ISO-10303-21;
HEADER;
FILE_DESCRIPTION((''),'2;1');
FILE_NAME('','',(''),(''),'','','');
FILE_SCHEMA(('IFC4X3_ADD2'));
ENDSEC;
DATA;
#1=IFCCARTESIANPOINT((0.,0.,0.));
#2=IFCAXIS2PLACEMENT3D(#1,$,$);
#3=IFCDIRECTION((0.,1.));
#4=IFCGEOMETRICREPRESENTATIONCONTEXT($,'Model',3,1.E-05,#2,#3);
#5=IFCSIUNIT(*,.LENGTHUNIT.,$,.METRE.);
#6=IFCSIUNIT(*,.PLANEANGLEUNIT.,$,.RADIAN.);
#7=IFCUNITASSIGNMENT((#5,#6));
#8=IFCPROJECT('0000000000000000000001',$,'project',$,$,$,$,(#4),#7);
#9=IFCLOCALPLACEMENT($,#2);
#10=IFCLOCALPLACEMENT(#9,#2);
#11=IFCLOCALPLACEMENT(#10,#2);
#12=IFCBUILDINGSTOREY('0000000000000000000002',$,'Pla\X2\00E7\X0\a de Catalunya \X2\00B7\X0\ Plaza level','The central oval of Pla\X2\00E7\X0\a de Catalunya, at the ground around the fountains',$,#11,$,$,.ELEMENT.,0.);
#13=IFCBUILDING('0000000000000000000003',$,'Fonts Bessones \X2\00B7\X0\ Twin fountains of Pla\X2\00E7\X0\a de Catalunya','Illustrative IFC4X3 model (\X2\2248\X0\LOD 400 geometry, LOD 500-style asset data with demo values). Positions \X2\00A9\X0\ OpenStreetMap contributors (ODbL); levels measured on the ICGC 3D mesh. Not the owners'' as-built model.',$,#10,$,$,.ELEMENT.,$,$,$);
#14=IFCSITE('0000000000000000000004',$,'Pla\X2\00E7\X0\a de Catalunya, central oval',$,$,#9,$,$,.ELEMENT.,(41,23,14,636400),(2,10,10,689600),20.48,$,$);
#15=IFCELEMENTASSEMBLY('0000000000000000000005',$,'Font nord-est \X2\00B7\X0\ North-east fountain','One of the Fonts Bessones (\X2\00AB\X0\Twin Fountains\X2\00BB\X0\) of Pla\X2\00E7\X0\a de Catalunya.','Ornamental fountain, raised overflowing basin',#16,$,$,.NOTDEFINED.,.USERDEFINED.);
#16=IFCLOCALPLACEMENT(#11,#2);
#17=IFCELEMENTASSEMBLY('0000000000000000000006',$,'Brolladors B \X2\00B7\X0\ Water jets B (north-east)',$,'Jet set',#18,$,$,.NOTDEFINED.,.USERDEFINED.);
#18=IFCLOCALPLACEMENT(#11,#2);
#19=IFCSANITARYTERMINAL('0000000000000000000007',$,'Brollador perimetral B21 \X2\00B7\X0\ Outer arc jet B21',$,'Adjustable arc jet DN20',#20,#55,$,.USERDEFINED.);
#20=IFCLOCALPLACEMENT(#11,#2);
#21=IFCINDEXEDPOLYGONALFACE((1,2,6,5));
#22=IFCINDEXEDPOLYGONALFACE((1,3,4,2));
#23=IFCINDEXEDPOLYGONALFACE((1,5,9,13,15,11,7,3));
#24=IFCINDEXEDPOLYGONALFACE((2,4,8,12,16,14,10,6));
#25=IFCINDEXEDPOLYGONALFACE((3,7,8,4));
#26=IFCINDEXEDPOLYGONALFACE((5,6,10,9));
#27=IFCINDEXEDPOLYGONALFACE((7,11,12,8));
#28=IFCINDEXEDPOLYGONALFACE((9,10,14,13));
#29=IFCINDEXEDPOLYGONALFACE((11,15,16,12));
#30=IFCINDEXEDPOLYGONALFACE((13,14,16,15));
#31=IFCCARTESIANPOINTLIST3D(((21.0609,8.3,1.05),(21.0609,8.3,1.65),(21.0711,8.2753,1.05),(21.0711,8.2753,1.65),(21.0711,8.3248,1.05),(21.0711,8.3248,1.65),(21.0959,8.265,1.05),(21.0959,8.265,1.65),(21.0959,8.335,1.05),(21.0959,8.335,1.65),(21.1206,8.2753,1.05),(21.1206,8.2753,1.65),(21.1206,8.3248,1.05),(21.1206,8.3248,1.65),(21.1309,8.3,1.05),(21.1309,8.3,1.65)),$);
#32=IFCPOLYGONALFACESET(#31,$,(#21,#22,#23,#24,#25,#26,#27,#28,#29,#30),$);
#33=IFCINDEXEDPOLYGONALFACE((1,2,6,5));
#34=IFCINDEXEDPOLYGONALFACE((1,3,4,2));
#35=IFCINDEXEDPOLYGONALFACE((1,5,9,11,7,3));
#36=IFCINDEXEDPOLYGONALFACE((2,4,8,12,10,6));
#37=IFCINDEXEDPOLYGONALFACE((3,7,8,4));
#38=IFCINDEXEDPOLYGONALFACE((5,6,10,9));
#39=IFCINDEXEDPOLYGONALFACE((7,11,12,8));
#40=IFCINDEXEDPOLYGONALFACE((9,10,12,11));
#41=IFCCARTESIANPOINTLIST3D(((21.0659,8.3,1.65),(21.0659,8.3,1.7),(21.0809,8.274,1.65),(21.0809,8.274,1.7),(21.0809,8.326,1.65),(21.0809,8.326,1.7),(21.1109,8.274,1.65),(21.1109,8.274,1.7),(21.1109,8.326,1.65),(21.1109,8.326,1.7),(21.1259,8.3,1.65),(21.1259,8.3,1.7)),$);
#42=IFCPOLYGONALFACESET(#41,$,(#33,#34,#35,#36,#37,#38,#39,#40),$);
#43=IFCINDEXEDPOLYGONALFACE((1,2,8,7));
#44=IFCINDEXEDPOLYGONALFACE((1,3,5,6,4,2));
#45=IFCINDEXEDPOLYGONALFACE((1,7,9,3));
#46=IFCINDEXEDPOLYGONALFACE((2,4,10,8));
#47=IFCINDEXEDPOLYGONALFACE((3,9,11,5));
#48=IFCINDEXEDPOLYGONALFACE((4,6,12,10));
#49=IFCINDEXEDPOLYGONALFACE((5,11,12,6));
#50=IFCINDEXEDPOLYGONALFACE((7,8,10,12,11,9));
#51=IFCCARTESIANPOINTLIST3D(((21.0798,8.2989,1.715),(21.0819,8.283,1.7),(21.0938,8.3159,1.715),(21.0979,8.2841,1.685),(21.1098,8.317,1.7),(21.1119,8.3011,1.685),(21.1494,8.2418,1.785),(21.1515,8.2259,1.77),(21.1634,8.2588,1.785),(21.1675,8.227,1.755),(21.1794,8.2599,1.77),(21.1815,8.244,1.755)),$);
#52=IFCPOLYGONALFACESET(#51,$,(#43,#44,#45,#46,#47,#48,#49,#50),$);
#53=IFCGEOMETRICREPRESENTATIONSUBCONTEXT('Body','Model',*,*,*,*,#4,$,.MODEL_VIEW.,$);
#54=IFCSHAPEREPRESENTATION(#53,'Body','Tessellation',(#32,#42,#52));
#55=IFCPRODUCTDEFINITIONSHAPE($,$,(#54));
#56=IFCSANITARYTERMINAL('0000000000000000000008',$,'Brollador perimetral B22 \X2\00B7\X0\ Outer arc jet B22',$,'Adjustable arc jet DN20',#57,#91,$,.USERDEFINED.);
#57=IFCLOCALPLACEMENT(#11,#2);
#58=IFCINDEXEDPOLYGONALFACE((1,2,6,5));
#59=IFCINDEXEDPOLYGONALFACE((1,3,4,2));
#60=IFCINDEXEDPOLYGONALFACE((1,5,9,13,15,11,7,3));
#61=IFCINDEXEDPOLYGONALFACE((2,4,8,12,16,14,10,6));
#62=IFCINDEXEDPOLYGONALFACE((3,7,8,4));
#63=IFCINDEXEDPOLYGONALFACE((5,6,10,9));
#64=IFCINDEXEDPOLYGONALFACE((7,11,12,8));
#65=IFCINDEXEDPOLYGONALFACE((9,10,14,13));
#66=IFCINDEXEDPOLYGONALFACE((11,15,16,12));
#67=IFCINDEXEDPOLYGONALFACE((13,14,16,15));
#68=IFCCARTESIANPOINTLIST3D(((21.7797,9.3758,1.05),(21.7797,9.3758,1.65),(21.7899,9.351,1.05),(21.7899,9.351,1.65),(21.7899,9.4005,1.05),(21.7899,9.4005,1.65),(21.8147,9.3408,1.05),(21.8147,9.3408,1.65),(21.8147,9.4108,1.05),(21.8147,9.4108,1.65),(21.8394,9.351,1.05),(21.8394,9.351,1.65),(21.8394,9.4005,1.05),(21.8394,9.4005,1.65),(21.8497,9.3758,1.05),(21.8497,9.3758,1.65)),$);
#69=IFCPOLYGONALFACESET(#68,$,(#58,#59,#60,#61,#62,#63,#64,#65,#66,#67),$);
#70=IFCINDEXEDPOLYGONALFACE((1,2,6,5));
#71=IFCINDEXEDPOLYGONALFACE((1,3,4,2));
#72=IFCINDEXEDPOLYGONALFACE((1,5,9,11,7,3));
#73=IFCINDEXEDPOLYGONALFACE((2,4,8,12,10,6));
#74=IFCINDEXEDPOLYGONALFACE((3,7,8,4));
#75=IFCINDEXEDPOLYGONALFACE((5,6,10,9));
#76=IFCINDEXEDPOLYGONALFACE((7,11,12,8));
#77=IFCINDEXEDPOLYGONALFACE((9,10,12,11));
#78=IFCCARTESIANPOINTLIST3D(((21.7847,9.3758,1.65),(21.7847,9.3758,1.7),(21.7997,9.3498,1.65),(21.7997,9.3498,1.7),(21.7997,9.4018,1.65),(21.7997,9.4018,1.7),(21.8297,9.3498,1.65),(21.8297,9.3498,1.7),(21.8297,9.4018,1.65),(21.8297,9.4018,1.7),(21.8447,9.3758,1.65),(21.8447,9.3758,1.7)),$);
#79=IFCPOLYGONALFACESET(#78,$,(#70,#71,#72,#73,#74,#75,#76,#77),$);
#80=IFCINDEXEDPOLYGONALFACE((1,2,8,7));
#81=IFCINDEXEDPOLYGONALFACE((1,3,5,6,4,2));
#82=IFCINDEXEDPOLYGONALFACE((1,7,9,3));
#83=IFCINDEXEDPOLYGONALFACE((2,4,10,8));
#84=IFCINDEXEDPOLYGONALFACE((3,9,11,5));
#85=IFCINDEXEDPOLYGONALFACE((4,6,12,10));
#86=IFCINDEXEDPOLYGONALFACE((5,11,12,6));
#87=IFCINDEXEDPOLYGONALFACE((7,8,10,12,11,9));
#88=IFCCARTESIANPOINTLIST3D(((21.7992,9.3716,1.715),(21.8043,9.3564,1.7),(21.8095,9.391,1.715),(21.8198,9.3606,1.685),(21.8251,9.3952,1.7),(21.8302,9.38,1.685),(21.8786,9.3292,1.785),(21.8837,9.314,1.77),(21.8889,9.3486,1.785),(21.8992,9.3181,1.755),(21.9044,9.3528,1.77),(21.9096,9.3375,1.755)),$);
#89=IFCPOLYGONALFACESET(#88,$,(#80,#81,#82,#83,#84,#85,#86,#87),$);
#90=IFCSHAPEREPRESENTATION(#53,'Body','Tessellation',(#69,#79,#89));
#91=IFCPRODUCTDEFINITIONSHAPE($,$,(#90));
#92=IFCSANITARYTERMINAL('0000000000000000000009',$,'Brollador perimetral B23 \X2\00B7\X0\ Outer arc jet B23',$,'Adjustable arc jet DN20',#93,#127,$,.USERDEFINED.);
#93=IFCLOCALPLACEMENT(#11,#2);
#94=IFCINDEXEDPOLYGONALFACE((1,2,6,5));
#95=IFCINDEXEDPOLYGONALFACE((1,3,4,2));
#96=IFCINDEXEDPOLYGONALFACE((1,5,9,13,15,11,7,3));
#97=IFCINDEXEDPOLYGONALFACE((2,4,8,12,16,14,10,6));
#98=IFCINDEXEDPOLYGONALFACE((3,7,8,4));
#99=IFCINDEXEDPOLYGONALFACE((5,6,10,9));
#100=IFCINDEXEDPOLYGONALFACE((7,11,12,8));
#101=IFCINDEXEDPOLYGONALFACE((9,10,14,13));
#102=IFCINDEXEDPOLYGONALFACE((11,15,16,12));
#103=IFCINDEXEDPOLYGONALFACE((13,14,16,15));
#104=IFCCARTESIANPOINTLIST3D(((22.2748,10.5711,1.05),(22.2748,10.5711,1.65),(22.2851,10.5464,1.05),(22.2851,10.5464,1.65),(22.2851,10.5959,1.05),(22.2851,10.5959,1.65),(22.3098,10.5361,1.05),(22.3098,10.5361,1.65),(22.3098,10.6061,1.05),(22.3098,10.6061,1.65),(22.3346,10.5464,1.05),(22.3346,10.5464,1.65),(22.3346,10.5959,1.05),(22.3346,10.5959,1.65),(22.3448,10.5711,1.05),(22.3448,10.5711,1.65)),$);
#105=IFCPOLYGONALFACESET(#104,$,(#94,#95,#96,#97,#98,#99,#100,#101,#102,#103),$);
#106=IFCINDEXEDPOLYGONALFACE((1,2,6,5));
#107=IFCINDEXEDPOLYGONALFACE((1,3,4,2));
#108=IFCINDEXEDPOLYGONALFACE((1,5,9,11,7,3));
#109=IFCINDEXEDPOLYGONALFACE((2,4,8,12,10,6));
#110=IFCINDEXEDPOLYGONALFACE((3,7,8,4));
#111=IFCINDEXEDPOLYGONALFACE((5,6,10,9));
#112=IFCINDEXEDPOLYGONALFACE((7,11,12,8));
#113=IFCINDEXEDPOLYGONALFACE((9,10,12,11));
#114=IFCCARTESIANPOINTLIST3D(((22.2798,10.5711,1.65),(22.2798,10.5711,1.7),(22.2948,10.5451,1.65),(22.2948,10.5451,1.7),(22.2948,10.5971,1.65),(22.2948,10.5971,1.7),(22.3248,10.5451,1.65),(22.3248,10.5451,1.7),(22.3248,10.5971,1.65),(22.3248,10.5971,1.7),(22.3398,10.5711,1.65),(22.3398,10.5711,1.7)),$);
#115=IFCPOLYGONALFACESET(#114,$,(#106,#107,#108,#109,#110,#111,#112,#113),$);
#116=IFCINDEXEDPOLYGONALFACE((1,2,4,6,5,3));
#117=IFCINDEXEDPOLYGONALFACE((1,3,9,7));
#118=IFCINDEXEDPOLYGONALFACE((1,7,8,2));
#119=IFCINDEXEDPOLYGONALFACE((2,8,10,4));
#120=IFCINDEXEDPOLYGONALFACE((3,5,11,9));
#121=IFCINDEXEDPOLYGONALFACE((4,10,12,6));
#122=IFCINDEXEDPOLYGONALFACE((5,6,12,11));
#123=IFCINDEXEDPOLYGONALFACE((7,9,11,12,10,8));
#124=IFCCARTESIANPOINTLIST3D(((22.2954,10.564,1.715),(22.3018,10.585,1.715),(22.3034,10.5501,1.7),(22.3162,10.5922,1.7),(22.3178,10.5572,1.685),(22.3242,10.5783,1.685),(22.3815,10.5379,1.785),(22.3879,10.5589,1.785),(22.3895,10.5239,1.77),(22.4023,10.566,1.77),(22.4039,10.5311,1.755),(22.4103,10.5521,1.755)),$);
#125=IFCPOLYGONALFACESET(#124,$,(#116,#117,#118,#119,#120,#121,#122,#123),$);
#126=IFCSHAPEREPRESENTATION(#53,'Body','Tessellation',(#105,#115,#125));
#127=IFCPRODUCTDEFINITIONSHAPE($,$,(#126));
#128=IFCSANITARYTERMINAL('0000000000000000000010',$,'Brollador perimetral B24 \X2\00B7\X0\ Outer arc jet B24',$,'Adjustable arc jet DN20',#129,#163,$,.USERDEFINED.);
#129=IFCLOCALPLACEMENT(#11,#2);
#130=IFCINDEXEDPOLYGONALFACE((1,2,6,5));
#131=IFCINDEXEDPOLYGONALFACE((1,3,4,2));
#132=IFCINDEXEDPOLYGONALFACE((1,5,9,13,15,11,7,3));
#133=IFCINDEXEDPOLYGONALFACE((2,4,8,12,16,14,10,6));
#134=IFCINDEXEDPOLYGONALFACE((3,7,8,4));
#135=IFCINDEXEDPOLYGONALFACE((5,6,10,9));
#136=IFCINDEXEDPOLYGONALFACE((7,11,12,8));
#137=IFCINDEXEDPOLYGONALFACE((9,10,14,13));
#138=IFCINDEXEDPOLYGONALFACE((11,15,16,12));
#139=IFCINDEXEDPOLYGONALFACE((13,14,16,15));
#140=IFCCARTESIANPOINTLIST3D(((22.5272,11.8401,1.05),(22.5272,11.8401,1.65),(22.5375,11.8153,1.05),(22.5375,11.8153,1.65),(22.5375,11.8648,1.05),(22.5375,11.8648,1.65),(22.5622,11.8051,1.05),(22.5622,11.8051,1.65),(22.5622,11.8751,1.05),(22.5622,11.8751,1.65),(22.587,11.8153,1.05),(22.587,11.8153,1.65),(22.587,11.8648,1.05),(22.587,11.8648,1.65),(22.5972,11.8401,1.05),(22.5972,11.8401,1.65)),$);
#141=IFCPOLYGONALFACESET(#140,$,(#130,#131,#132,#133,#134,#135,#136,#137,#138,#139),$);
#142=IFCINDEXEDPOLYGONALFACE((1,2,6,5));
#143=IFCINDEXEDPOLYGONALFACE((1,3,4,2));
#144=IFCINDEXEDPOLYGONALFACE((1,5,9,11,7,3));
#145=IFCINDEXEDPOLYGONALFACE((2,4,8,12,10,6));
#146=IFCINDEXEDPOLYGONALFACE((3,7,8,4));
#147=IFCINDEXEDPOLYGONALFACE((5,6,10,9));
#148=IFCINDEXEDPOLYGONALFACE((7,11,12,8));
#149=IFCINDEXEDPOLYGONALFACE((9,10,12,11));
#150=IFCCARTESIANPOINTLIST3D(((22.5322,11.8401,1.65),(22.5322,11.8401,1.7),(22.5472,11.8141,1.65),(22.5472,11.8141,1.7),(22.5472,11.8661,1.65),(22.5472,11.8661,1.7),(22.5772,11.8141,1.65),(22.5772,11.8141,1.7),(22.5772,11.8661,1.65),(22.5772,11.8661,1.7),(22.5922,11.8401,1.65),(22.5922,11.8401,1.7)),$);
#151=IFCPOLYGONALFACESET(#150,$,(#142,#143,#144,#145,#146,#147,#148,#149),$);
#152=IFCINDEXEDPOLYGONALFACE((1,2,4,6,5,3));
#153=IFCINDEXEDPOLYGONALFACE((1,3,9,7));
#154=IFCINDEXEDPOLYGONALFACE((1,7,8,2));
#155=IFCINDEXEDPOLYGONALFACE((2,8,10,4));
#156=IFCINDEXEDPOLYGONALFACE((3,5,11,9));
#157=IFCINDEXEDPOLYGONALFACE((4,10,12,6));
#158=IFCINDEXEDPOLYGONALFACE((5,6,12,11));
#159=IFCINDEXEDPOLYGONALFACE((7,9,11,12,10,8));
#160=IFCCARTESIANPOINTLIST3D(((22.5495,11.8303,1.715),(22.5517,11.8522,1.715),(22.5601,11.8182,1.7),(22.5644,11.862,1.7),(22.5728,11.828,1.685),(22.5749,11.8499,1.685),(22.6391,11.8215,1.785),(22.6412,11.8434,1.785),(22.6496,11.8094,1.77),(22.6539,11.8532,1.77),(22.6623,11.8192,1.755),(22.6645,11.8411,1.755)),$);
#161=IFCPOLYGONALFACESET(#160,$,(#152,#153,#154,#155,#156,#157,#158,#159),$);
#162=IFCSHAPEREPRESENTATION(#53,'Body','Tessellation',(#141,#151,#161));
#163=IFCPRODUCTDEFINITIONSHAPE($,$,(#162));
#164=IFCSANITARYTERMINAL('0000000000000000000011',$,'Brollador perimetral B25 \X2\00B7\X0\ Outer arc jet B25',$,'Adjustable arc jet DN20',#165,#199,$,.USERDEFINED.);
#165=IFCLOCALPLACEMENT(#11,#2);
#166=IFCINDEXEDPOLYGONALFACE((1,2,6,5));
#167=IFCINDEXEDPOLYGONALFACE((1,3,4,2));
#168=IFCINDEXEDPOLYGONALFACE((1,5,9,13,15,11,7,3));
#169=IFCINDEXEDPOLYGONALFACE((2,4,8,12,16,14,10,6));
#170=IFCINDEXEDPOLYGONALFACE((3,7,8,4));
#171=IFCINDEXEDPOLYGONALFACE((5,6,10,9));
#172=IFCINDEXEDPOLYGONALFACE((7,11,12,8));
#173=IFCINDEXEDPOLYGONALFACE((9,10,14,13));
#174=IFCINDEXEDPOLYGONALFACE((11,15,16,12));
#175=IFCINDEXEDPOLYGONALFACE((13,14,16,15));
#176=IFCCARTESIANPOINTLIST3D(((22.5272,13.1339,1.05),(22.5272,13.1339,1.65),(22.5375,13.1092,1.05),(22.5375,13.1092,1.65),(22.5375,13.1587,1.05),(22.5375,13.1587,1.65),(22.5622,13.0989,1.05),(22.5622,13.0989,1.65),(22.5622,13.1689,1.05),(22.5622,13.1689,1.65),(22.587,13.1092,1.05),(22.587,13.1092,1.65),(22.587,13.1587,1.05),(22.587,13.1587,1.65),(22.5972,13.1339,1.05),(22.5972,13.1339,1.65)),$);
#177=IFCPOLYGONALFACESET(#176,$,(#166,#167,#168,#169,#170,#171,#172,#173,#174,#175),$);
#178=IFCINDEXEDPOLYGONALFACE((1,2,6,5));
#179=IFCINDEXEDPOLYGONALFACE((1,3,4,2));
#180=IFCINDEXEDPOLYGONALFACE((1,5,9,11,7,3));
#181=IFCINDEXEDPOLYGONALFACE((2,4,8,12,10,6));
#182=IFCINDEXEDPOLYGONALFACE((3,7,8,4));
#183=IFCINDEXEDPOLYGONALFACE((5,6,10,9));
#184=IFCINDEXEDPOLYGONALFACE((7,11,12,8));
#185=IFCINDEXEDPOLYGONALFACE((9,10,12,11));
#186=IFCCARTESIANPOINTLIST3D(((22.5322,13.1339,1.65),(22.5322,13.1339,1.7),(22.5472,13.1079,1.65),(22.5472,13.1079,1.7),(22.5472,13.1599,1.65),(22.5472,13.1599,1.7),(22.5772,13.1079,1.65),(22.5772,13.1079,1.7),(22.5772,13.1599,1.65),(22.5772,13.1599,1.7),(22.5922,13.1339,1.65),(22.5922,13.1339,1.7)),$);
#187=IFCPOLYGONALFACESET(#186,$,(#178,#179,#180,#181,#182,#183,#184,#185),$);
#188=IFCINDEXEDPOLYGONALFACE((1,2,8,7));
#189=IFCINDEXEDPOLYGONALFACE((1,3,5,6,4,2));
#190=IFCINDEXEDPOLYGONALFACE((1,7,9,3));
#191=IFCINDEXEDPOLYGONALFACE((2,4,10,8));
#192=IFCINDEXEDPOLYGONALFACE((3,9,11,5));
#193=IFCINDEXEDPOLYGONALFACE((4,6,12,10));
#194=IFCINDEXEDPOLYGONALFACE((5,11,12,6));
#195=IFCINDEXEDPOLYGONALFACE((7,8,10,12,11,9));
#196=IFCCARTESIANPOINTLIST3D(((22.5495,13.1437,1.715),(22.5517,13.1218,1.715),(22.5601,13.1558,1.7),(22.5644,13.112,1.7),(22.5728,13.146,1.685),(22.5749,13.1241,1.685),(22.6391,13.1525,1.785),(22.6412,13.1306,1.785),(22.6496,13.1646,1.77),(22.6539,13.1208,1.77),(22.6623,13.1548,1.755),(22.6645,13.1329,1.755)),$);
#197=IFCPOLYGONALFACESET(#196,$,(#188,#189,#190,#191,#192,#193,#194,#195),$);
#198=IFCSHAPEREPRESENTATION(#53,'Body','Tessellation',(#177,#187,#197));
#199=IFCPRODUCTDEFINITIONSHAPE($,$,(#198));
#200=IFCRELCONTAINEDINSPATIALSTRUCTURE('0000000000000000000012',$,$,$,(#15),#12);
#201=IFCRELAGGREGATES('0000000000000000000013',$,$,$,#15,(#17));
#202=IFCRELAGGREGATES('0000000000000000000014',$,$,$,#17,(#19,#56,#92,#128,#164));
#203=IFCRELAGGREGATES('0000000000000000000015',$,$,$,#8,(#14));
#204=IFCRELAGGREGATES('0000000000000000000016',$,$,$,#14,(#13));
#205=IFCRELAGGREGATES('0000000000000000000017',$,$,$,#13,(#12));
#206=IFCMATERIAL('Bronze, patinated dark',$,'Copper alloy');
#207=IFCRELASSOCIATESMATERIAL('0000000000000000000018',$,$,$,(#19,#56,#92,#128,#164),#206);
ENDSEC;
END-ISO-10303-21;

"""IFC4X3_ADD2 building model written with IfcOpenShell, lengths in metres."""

from ifc_helpers import new_model, si_unit, direction, frame, origin, place, context, subcontext, project, spatial, polyline, outline, extrude, material, element, aggregate, save


model = new_model("IFC4X3_ADD2")

# Units and contexts
model_context = context("Model", 3, precision=1e-05, world=origin(), true_north=direction((0.0, 1.0)))
body_context = subcontext(model_context, "Body", "Model", "MODEL_VIEW")
ifc_project = project(units=[si_unit("LENGTHUNIT", "METRE"), si_unit("PLANEANGLEUNIT", "RADIAN")], contexts=[model_context])

# Site, building, storey
site_placement = place(None, origin())
site = spatial("IfcSite", under=ifc_project, at=site_placement, Name="Plaça de Catalunya, central oval", CompositionType="ELEMENT", RefLatitude=(41, 23, 14, 636400), RefLongitude=(2, 10, 10, 689600), RefElevation=20.48)
building_placement = place(site_placement, origin())
building = spatial("IfcBuilding", under=site, at=building_placement, Name="Fonts Bessones · Twin fountains of Plaça de Catalunya", Description="Illustrative IFC4X3 model (≈LOD 400 geometry, LOD 500-style asset data with demo values). Positions © OpenStreetMap contributors (ODbL); levels measured on the ICGC 3D mesh. Not the owners' as-built model.", CompositionType="ELEMENT")
storey_placement = place(building_placement, origin())
storey = spatial("IfcBuildingStorey", under=building, at=storey_placement, Name="Plaça de Catalunya · Plaza level", Description="The central oval of Plaça de Catalunya, at the ground around the fountains", CompositionType="ELEMENT", Elevation=0.0)

# Element assemblies, sanitary terminals
assembly_1_placement = place(building_placement, origin())
assembly_1 = element("IfcElementAssembly", 1, at=assembly_1_placement, inside=storey, Name="Font nord-est · North-east fountain", Description="One of the Fonts Bessones («Twin Fountains») of Plaça de Catalunya.", ObjectType="Ornamental fountain, raised overflowing basin", AssemblyPlace="NOTDEFINED", PredefinedType="USERDEFINED")
assembly_2_placement = place(building_placement, origin())
assembly_2 = element("IfcElementAssembly", 2, at=assembly_2_placement, Name="Brolladors B · Water jets B (north-east)", ObjectType="Jet set", AssemblyPlace="NOTDEFINED", PredefinedType="USERDEFINED")
aggregate(assembly_1, [assembly_2])
ifc_material_1 = material(Name="Bronze, patinated dark", Category="Copper alloy")
sanitary_terminal_1_placement = place(building_placement, origin())
sanitary_terminal_1 = element("IfcSanitaryTerminal", 3, at=sanitary_terminal_1_placement, material=ifc_material_1, Name="Brollador perimetral B21 · Outer arc jet B21", ObjectType="Adjustable arc jet DN20", PredefinedType="USERDEFINED", context=body_context, shape_type="SweptSolid", body=[
    extrude(outline(polyline([(21.1309, 8.3), (21.1206, 8.3248), (21.0959, 8.335), (21.0711, 8.3248), (21.0609, 8.3), (21.0711, 8.2753), (21.0959, 8.265), (21.1206, 8.2753), (21.1309, 8.3)])), frame((0.0, 0.0, 1.05)), (0.0, 0.0, 1.0), 0.6),
    extrude(outline(polyline([(21.1259, 8.3), (21.1109, 8.326), (21.0809, 8.326), (21.0659, 8.3), (21.0809, 8.274), (21.1109, 8.274), (21.1259, 8.3)])), frame((0.0, 0.0, 1.65)), (0.0, 0.0, 1.0), 0.05),
    extrude(outline(polyline([(0.022, 0.0), (0.011, 0.0191), (-0.011, 0.0191), (-0.022, 0.0), (-0.011, -0.0191), (0.011, -0.0191), (0.022, 0.0)])), frame((21.0959, 8.3, 1.7), z_axis=(0.610178, -0.50076, 0.613941), x_axis=(-0.634393, -0.77301, 0.0)), (0.0, 0.0, 1.0), 0.114),
])
sanitary_terminal_2_placement = place(building_placement, origin())
sanitary_terminal_2 = element("IfcSanitaryTerminal", 4, at=sanitary_terminal_2_placement, material=ifc_material_1, Name="Brollador perimetral B22 · Outer arc jet B22", ObjectType="Adjustable arc jet DN20", PredefinedType="USERDEFINED", context=body_context, shape_type="SweptSolid", body=[
    extrude(outline(polyline([(21.8497, 9.3758), (21.8394, 9.4005), (21.8147, 9.4108), (21.7899, 9.4005), (21.7797, 9.3758), (21.7899, 9.351), (21.8147, 9.3408), (21.8394, 9.351), (21.8497, 9.3758)])), frame((0.0, 0.0, 1.05)), (0.0, 0.0, 1.0), 0.6),
    extrude(outline(polyline([(21.8447, 9.3758), (21.8297, 9.4018), (21.7997, 9.4018), (21.7847, 9.3758), (21.7997, 9.3498), (21.8297, 9.3498), (21.8447, 9.3758)])), frame((0.0, 0.0, 1.65)), (0.0, 0.0, 1.0), 0.05),
    extrude(outline(polyline([(0.022, 0.0), (0.011, 0.0191), (-0.011, 0.0191), (-0.022, 0.0), (-0.011, -0.0191), (0.011, -0.0191), (0.022, 0.0)])), frame((21.8147, 9.3758, 1.7), z_axis=(0.696147, -0.372098, 0.613941), x_axis=(-0.471397, -0.881921, 0.0)), (0.0, 0.0, 1.0), 0.114),
])
sanitary_terminal_3_placement = place(building_placement, origin())
sanitary_terminal_3 = element("IfcSanitaryTerminal", 5, at=sanitary_terminal_3_placement, material=ifc_material_1, Name="Brollador perimetral B23 · Outer arc jet B23", ObjectType="Adjustable arc jet DN20", PredefinedType="USERDEFINED", context=body_context, shape_type="SweptSolid", body=[
    extrude(outline(polyline([(22.3448, 10.5711), (22.3346, 10.5959), (22.3098, 10.6061), (22.2851, 10.5959), (22.2748, 10.5711), (22.2851, 10.5464), (22.3098, 10.5361), (22.3346, 10.5464), (22.3448, 10.5711)])), frame((0.0, 0.0, 1.05)), (0.0, 0.0, 1.0), 0.6),
    extrude(outline(polyline([(22.3398, 10.5711), (22.3248, 10.5971), (22.2948, 10.5971), (22.2798, 10.5711), (22.2948, 10.5451), (22.3248, 10.5451), (22.3398, 10.5711)])), frame((0.0, 0.0, 1.65)), (0.0, 0.0, 1.0), 0.05),
    extrude(outline(polyline([(0.022, 0.0), (0.011, 0.0191), (-0.011, 0.0191), (-0.022, 0.0), (-0.011, -0.0191), (0.011, -0.0191), (0.022, 0.0)])), frame((22.3098, 10.5711, 1.7), z_axis=(0.755363, -0.229137, 0.613941), x_axis=(-0.290285, -0.95694, 0.0)), (0.0, 0.0, 1.0), 0.114),
])
sanitary_terminal_4_placement = place(building_placement, origin())
sanitary_terminal_4 = element("IfcSanitaryTerminal", 6, at=sanitary_terminal_4_placement, material=ifc_material_1, Name="Brollador perimetral B24 · Outer arc jet B24", ObjectType="Adjustable arc jet DN20", PredefinedType="USERDEFINED", context=body_context, shape_type="SweptSolid", body=[
    extrude(outline(polyline([(22.5972, 11.8401), (22.587, 11.8648), (22.5622, 11.8751), (22.5375, 11.8648), (22.5272, 11.8401), (22.5375, 11.8153), (22.5622, 11.8051), (22.587, 11.8153), (22.5972, 11.8401)])), frame((0.0, 0.0, 1.05)), (0.0, 0.0, 1.0), 0.6),
    extrude(outline(polyline([(22.5922, 11.8401), (22.5772, 11.8661), (22.5472, 11.8661), (22.5322, 11.8401), (22.5472, 11.8141), (22.5772, 11.8141), (22.5922, 11.8401)])), frame((0.0, 0.0, 1.65)), (0.0, 0.0, 1.0), 0.05),
    extrude(outline(polyline([(0.022, 0.0), (0.011, 0.0191), (-0.011, 0.0191), (-0.022, 0.0), (-0.011, -0.0191), (0.011, -0.0191), (0.022, 0.0)])), frame((22.5622, 11.8401, 1.7), z_axis=(0.785551, -0.07737, 0.613941), x_axis=(-0.098017, -0.995185, 0.0)), (0.0, 0.0, 1.0), 0.114),
])
sanitary_terminal_5_placement = place(building_placement, origin())
sanitary_terminal_5 = element("IfcSanitaryTerminal", 7, at=sanitary_terminal_5_placement, material=ifc_material_1, Name="Brollador perimetral B25 · Outer arc jet B25", ObjectType="Adjustable arc jet DN20", PredefinedType="USERDEFINED", context=body_context, shape_type="SweptSolid", body=[
    extrude(outline(polyline([(22.5972, 13.1339), (22.587, 13.1587), (22.5622, 13.1689), (22.5375, 13.1587), (22.5272, 13.1339), (22.5375, 13.1092), (22.5622, 13.0989), (22.587, 13.1092), (22.5972, 13.1339)])), frame((0.0, 0.0, 1.05)), (0.0, 0.0, 1.0), 0.6),
    extrude(outline(polyline([(22.5922, 13.1339), (22.5772, 13.1599), (22.5472, 13.1599), (22.5322, 13.1339), (22.5472, 13.1079), (22.5772, 13.1079), (22.5922, 13.1339)])), frame((0.0, 0.0, 1.65)), (0.0, 0.0, 1.0), 0.05),
    extrude(outline(polyline([(0.022, 0.0), (0.011, 0.0191), (-0.011, 0.0191), (-0.022, 0.0), (-0.011, -0.0191), (0.011, -0.0191), (0.022, 0.0)])), frame((22.5622, 13.1339, 1.7), z_axis=(0.785551, 0.07737, 0.613941), x_axis=(0.098017, -0.995185, 0.0)), (0.0, 0.0, 1.0), 0.114),
])
aggregate(assembly_2, [sanitary_terminal_1, sanitary_terminal_2, sanitary_terminal_3, sanitary_terminal_4, sanitary_terminal_5])

save(model, "model.ifc")
